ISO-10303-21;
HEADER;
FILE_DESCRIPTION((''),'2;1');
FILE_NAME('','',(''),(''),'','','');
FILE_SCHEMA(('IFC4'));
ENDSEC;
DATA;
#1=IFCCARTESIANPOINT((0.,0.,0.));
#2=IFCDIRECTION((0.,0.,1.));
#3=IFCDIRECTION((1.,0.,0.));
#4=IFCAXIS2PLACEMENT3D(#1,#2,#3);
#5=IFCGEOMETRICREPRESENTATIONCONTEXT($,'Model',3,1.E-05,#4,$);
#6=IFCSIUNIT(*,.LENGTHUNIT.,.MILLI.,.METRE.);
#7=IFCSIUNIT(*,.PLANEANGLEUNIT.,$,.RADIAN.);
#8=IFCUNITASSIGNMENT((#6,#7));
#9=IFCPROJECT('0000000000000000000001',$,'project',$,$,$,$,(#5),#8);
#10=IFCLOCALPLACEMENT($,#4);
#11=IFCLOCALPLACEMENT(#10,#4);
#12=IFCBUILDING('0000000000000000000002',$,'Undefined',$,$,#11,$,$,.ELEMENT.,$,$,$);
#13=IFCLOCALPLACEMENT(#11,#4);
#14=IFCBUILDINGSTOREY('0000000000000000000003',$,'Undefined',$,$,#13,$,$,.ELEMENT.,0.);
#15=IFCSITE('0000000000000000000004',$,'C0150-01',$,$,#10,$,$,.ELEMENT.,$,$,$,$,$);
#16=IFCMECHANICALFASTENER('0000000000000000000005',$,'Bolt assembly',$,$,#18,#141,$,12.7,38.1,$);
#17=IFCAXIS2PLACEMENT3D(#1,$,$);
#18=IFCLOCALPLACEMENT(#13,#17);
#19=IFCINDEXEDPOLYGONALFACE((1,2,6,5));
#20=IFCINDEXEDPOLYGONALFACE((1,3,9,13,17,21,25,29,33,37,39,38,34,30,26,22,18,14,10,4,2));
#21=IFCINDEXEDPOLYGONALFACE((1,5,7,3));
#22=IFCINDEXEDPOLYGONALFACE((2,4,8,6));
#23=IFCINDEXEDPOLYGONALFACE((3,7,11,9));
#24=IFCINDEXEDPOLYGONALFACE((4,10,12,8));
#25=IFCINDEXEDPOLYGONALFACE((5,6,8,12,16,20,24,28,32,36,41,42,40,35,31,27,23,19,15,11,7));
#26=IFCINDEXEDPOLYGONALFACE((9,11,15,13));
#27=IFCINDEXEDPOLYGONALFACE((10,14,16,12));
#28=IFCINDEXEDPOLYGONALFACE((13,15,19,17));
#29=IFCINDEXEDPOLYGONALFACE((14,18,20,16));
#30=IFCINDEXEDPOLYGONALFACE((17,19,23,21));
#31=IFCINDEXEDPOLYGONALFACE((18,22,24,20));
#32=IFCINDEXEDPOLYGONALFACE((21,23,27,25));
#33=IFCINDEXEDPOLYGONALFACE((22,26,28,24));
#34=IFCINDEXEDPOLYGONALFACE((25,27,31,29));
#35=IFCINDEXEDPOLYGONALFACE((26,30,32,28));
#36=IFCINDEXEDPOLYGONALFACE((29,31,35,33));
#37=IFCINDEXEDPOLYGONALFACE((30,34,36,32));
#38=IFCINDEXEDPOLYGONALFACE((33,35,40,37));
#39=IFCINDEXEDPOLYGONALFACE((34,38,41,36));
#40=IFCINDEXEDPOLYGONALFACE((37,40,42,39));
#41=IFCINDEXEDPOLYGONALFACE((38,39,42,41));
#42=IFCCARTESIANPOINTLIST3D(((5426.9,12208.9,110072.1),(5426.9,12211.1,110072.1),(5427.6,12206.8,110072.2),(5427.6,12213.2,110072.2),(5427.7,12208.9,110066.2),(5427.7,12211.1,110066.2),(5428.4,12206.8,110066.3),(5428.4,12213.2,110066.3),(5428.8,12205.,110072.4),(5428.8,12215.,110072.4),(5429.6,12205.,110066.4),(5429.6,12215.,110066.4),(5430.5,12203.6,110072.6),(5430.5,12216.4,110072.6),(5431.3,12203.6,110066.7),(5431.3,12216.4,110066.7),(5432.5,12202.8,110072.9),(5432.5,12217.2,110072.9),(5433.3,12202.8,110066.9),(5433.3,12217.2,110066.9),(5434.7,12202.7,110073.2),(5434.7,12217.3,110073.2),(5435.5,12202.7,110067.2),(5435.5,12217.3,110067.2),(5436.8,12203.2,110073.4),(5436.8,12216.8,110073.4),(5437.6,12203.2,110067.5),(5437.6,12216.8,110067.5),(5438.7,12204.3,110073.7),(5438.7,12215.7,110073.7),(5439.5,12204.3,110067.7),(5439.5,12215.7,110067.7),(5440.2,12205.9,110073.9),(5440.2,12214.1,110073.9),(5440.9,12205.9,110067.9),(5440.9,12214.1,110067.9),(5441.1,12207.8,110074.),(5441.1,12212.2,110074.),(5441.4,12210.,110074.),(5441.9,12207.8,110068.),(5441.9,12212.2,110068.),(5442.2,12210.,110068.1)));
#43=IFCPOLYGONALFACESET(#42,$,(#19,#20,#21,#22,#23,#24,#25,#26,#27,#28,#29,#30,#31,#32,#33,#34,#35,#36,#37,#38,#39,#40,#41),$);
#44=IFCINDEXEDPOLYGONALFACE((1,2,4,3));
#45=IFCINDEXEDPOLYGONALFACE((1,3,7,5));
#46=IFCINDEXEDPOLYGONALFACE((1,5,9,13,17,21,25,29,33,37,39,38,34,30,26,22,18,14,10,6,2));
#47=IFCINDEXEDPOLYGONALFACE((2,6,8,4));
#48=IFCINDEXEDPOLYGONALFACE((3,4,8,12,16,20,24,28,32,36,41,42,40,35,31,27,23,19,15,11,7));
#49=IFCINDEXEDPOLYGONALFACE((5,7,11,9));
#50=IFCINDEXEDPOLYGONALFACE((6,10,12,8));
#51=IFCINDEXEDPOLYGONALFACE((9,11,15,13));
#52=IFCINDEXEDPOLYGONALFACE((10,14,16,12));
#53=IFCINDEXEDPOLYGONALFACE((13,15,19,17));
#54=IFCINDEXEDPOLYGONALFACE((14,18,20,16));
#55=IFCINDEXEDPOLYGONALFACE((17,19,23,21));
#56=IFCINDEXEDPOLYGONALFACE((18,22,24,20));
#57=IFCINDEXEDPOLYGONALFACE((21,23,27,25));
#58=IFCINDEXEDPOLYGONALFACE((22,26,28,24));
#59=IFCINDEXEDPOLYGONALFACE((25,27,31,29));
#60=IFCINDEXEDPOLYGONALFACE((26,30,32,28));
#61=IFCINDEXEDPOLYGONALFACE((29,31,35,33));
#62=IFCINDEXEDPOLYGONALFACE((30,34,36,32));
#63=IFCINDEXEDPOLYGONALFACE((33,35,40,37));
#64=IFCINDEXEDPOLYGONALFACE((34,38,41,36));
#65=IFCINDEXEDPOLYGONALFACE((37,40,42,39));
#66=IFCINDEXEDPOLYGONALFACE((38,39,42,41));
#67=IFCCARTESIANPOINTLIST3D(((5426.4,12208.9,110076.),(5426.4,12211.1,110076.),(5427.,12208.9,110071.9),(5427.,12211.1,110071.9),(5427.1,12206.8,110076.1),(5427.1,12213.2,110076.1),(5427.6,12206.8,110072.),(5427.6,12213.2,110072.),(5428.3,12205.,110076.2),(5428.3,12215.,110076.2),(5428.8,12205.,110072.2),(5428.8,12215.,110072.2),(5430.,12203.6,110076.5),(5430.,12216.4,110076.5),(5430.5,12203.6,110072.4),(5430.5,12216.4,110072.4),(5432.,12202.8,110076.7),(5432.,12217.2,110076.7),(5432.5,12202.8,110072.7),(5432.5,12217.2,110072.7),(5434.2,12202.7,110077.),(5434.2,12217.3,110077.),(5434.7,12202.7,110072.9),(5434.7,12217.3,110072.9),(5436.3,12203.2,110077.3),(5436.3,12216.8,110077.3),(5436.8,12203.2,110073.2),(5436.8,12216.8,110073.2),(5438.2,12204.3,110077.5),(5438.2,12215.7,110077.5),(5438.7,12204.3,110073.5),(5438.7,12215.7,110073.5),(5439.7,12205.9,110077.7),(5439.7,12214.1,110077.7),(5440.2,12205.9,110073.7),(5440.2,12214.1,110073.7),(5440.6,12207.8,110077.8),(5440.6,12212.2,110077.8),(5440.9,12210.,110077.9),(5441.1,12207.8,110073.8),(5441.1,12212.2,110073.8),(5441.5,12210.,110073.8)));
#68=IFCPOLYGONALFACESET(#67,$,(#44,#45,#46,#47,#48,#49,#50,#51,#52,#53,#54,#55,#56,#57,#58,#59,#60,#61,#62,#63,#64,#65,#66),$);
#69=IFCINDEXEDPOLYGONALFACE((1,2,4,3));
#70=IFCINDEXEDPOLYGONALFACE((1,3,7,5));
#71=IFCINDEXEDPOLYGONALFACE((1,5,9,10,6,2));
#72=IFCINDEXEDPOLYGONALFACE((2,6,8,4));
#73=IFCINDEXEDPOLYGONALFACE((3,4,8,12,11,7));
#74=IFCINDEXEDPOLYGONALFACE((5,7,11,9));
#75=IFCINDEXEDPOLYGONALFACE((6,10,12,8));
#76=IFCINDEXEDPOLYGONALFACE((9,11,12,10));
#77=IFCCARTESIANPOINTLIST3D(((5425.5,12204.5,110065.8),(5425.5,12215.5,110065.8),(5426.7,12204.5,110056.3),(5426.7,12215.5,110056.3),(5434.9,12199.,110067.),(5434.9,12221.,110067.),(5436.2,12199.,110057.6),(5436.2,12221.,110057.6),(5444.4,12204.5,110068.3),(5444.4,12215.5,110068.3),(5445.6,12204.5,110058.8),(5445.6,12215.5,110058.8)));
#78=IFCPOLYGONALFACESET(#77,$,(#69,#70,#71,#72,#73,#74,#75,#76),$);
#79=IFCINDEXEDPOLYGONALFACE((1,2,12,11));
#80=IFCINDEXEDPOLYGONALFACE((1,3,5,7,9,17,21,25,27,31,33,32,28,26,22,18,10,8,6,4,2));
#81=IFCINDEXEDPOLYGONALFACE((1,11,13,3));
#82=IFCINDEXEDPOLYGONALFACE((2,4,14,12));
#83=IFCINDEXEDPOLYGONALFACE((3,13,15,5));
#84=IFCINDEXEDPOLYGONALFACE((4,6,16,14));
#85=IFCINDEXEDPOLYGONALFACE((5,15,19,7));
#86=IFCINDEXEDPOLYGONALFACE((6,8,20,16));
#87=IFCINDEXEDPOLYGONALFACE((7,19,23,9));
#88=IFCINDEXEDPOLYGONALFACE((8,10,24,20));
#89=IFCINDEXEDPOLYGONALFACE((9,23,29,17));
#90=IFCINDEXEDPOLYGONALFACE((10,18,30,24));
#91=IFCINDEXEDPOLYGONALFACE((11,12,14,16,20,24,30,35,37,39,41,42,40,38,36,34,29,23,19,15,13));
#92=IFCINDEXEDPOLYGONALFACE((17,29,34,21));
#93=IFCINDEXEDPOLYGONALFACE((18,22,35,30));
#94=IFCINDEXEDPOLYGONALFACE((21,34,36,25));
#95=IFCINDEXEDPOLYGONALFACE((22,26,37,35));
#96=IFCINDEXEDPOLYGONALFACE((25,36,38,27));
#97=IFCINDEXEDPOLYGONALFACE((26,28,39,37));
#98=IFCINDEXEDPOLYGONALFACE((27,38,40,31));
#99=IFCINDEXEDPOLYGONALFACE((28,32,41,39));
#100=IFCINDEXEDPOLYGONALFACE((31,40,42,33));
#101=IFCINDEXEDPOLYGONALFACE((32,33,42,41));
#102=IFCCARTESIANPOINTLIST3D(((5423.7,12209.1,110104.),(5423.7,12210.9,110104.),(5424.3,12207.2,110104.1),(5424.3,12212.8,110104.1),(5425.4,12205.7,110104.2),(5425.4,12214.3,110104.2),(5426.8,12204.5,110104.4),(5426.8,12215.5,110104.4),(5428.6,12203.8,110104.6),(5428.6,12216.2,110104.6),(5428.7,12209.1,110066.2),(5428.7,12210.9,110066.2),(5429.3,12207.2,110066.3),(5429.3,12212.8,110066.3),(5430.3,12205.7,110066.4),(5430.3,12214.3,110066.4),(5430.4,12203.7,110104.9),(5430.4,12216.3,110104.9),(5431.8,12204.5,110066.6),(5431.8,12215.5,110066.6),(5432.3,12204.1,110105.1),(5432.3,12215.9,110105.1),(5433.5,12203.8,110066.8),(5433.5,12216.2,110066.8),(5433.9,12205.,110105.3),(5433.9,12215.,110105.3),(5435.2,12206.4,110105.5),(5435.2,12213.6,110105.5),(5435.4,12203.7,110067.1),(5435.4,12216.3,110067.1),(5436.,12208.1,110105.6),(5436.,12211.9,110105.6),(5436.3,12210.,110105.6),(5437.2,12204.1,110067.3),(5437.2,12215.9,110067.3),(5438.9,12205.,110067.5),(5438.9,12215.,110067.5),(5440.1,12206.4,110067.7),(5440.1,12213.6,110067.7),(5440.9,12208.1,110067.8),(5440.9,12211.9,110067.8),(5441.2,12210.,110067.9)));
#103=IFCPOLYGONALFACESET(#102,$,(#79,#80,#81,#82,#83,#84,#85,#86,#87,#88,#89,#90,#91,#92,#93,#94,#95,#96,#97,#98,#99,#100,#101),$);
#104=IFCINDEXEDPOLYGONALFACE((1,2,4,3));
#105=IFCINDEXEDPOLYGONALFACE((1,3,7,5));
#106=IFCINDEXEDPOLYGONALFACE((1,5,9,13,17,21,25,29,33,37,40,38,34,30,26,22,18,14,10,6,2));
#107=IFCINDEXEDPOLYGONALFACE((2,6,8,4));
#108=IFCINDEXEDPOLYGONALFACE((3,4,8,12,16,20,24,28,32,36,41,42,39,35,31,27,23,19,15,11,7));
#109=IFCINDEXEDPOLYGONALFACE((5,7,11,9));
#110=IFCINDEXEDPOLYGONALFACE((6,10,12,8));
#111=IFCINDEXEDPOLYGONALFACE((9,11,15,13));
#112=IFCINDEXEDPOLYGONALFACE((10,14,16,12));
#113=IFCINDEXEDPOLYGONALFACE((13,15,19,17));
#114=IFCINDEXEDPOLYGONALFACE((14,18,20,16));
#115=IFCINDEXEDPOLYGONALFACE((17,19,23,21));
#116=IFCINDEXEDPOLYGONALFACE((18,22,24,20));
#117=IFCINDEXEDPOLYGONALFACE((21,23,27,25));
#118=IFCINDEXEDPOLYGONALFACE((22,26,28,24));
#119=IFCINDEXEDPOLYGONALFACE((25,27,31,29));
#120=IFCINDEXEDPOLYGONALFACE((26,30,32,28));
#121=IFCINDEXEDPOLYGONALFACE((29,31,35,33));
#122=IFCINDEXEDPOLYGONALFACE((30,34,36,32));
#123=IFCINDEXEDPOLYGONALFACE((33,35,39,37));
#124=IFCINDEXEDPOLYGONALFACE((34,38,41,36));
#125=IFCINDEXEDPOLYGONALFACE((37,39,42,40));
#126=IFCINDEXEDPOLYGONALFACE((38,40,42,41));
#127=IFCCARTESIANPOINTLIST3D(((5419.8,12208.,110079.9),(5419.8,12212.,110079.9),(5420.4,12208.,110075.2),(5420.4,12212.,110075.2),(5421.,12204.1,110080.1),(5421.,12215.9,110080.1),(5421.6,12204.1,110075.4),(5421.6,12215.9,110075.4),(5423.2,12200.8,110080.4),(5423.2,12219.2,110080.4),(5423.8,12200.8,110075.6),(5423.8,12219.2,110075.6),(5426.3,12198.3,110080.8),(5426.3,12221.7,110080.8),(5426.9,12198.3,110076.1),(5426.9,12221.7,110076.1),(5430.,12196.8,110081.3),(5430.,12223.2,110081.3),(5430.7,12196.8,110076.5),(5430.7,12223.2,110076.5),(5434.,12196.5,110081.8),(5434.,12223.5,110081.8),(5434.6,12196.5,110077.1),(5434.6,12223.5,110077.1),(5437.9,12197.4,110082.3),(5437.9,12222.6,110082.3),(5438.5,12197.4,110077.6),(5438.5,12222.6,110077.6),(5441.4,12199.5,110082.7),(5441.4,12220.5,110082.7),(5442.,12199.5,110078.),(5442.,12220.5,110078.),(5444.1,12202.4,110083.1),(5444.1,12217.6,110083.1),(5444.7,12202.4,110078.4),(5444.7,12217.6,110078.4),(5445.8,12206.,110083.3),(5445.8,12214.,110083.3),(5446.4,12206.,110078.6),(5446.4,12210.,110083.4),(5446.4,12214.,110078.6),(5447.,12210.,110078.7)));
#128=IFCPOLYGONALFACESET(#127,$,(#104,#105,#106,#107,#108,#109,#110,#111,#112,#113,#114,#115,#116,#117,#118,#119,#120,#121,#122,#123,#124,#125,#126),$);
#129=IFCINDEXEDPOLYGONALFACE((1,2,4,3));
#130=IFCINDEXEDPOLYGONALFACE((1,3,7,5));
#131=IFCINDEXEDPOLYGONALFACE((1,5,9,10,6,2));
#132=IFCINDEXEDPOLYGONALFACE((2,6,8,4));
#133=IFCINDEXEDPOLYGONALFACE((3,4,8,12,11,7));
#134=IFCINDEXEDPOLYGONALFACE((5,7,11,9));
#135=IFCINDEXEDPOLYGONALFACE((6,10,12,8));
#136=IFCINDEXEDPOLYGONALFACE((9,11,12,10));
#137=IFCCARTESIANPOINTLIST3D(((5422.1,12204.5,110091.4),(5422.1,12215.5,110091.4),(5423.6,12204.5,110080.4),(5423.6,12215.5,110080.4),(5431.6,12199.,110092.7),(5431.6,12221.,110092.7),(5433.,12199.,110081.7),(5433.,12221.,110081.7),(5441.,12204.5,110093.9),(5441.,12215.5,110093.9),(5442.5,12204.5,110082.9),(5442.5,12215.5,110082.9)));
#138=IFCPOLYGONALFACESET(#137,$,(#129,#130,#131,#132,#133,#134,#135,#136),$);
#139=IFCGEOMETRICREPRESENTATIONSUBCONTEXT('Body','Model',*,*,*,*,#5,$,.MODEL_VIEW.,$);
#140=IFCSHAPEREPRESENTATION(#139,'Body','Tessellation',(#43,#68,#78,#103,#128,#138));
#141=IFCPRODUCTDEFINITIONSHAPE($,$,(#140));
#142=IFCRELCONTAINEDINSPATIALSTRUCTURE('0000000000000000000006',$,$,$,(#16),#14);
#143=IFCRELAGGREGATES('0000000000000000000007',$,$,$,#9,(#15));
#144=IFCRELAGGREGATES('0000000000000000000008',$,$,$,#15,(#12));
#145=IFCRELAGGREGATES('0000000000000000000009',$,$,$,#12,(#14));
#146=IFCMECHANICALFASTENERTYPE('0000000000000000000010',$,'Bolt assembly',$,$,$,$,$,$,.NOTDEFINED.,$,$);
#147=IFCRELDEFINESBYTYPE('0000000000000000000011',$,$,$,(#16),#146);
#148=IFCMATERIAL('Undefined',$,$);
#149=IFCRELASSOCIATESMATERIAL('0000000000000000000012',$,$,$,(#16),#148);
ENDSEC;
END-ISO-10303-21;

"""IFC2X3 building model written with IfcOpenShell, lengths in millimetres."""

from ifc_helpers import new_model, si_unit, frame, origin_with_axes, origin_2d_with_axis, place, context, subcontext, project, spatial, polyline, circle, outline, extrude, source, transform, mapped, material, type_object, element, save


model = new_model("IFC2X3")

# Units and contexts
model_context = context("Model", 3, precision=1e-05, world=origin_with_axes())
body_context = subcontext(model_context, "Body", "Model", "MODEL_VIEW")
ifc_project = project(units=[si_unit("LENGTHUNIT", "METRE", prefix="MILLI"), si_unit("PLANEANGLEUNIT", "RADIAN")], contexts=[model_context])

# Site, building, storey
site_placement = place(None, origin_with_axes())
site = spatial("IfcSite", under=ifc_project, at=site_placement, Name="C0150-01", CompositionType="ELEMENT")
building_placement = place(site_placement, origin_with_axes())
building = spatial("IfcBuilding", under=site, at=building_placement, Name="Undefined", CompositionType="ELEMENT")
storey_placement = place(building_placement, origin_with_axes())
storey = spatial("IfcBuildingStorey", under=building, at=storey_placement, Name="Undefined", CompositionType="ELEMENT", Elevation=0.0)

# Mechanical fastener
ifc_material_1 = material(Name="Undefined")
mechanical_fastener_type = type_object("IfcMechanicalFastenerType", Name="Bolt assembly")
shared_shape_1 = source(origin_with_axes(), body_context, "Body", "SweptSolid", [
    extrude(circle(Radius=7.3, at=origin_2d_with_axis()), frame((0.0, -9.9, 0.0), z_axis=(0.0, 1.0, 0.0), x_axis=(1.0, 0.0, 0.0)), (0.0, 0.0, 1.0), 6.0),
    extrude(circle(Radius=7.3, at=origin_2d_with_axis()), frame((0.0, -4.1, 0.0), z_axis=(0.0, 1.0, 0.0), x_axis=(1.0, 0.0, 0.0)), (0.0, 0.0, 1.0), 4.1),
    extrude(outline(polyline([(9.5, -5.5), (9.5, 5.5), (0.0, 11.0), (-9.5, 5.5), (-9.5, -5.5), (0.0, -11.0), (9.5, -5.5)])), frame((0.0, -19.5, 0.0), z_axis=(0.0, 1.0, 0.0), x_axis=(1.0, 0.0, 0.0)), (0.0, 0.0, 1.0), 9.5),
    extrude(circle(Radius=6.3, at=origin_2d_with_axis()), frame((0.0, -10.0, 0.0), z_axis=(0.0, 1.0, 0.0), x_axis=(1.0, 0.0, 0.0)), (0.0, 0.0, 1.0), 38.1),
    extrude(circle(Radius=13.5, at=origin_2d_with_axis()), frame((0.0, 0.0, 0.0), z_axis=(0.0, 1.0, 0.0), x_axis=(1.0, 0.0, 0.0)), (0.0, 0.0, 1.0), 4.8),
    extrude(outline(polyline([(9.5, -5.5), (9.5, 5.5), (0.0, 11.0), (-9.5, 5.5), (-9.5, -5.5), (0.0, -11.0), (9.5, -5.5)])), frame((0.0, 4.8, 0.0), z_axis=(0.0, 1.0, 0.0), x_axis=(1.0, 0.0, 0.0)), (0.0, 0.0, 1.0), 11.1),
])
for number, where, z_axis, x_axis, name in (
    (1, (5433.6, 12210.0, 110076.9), (0.0, -1.0, 0.0), (0.991507, 0.0, 0.130054), "Bolt assembly"),
):
    element("IfcMechanicalFastener", number, at=place(storey_placement, frame(where, z_axis=z_axis, x_axis=x_axis)), inside=storey, type_object=mechanical_fastener_type, material=ifc_material_1, Name=name, NominalDiameter=12.7, NominalLength=38.1, context=body_context, shape_type="MappedRepresentation", body=[
        mapped(shared_shape_1, transform((0.0, 0.0, 0.0))),
    ])

save(model, "model.ifc")
